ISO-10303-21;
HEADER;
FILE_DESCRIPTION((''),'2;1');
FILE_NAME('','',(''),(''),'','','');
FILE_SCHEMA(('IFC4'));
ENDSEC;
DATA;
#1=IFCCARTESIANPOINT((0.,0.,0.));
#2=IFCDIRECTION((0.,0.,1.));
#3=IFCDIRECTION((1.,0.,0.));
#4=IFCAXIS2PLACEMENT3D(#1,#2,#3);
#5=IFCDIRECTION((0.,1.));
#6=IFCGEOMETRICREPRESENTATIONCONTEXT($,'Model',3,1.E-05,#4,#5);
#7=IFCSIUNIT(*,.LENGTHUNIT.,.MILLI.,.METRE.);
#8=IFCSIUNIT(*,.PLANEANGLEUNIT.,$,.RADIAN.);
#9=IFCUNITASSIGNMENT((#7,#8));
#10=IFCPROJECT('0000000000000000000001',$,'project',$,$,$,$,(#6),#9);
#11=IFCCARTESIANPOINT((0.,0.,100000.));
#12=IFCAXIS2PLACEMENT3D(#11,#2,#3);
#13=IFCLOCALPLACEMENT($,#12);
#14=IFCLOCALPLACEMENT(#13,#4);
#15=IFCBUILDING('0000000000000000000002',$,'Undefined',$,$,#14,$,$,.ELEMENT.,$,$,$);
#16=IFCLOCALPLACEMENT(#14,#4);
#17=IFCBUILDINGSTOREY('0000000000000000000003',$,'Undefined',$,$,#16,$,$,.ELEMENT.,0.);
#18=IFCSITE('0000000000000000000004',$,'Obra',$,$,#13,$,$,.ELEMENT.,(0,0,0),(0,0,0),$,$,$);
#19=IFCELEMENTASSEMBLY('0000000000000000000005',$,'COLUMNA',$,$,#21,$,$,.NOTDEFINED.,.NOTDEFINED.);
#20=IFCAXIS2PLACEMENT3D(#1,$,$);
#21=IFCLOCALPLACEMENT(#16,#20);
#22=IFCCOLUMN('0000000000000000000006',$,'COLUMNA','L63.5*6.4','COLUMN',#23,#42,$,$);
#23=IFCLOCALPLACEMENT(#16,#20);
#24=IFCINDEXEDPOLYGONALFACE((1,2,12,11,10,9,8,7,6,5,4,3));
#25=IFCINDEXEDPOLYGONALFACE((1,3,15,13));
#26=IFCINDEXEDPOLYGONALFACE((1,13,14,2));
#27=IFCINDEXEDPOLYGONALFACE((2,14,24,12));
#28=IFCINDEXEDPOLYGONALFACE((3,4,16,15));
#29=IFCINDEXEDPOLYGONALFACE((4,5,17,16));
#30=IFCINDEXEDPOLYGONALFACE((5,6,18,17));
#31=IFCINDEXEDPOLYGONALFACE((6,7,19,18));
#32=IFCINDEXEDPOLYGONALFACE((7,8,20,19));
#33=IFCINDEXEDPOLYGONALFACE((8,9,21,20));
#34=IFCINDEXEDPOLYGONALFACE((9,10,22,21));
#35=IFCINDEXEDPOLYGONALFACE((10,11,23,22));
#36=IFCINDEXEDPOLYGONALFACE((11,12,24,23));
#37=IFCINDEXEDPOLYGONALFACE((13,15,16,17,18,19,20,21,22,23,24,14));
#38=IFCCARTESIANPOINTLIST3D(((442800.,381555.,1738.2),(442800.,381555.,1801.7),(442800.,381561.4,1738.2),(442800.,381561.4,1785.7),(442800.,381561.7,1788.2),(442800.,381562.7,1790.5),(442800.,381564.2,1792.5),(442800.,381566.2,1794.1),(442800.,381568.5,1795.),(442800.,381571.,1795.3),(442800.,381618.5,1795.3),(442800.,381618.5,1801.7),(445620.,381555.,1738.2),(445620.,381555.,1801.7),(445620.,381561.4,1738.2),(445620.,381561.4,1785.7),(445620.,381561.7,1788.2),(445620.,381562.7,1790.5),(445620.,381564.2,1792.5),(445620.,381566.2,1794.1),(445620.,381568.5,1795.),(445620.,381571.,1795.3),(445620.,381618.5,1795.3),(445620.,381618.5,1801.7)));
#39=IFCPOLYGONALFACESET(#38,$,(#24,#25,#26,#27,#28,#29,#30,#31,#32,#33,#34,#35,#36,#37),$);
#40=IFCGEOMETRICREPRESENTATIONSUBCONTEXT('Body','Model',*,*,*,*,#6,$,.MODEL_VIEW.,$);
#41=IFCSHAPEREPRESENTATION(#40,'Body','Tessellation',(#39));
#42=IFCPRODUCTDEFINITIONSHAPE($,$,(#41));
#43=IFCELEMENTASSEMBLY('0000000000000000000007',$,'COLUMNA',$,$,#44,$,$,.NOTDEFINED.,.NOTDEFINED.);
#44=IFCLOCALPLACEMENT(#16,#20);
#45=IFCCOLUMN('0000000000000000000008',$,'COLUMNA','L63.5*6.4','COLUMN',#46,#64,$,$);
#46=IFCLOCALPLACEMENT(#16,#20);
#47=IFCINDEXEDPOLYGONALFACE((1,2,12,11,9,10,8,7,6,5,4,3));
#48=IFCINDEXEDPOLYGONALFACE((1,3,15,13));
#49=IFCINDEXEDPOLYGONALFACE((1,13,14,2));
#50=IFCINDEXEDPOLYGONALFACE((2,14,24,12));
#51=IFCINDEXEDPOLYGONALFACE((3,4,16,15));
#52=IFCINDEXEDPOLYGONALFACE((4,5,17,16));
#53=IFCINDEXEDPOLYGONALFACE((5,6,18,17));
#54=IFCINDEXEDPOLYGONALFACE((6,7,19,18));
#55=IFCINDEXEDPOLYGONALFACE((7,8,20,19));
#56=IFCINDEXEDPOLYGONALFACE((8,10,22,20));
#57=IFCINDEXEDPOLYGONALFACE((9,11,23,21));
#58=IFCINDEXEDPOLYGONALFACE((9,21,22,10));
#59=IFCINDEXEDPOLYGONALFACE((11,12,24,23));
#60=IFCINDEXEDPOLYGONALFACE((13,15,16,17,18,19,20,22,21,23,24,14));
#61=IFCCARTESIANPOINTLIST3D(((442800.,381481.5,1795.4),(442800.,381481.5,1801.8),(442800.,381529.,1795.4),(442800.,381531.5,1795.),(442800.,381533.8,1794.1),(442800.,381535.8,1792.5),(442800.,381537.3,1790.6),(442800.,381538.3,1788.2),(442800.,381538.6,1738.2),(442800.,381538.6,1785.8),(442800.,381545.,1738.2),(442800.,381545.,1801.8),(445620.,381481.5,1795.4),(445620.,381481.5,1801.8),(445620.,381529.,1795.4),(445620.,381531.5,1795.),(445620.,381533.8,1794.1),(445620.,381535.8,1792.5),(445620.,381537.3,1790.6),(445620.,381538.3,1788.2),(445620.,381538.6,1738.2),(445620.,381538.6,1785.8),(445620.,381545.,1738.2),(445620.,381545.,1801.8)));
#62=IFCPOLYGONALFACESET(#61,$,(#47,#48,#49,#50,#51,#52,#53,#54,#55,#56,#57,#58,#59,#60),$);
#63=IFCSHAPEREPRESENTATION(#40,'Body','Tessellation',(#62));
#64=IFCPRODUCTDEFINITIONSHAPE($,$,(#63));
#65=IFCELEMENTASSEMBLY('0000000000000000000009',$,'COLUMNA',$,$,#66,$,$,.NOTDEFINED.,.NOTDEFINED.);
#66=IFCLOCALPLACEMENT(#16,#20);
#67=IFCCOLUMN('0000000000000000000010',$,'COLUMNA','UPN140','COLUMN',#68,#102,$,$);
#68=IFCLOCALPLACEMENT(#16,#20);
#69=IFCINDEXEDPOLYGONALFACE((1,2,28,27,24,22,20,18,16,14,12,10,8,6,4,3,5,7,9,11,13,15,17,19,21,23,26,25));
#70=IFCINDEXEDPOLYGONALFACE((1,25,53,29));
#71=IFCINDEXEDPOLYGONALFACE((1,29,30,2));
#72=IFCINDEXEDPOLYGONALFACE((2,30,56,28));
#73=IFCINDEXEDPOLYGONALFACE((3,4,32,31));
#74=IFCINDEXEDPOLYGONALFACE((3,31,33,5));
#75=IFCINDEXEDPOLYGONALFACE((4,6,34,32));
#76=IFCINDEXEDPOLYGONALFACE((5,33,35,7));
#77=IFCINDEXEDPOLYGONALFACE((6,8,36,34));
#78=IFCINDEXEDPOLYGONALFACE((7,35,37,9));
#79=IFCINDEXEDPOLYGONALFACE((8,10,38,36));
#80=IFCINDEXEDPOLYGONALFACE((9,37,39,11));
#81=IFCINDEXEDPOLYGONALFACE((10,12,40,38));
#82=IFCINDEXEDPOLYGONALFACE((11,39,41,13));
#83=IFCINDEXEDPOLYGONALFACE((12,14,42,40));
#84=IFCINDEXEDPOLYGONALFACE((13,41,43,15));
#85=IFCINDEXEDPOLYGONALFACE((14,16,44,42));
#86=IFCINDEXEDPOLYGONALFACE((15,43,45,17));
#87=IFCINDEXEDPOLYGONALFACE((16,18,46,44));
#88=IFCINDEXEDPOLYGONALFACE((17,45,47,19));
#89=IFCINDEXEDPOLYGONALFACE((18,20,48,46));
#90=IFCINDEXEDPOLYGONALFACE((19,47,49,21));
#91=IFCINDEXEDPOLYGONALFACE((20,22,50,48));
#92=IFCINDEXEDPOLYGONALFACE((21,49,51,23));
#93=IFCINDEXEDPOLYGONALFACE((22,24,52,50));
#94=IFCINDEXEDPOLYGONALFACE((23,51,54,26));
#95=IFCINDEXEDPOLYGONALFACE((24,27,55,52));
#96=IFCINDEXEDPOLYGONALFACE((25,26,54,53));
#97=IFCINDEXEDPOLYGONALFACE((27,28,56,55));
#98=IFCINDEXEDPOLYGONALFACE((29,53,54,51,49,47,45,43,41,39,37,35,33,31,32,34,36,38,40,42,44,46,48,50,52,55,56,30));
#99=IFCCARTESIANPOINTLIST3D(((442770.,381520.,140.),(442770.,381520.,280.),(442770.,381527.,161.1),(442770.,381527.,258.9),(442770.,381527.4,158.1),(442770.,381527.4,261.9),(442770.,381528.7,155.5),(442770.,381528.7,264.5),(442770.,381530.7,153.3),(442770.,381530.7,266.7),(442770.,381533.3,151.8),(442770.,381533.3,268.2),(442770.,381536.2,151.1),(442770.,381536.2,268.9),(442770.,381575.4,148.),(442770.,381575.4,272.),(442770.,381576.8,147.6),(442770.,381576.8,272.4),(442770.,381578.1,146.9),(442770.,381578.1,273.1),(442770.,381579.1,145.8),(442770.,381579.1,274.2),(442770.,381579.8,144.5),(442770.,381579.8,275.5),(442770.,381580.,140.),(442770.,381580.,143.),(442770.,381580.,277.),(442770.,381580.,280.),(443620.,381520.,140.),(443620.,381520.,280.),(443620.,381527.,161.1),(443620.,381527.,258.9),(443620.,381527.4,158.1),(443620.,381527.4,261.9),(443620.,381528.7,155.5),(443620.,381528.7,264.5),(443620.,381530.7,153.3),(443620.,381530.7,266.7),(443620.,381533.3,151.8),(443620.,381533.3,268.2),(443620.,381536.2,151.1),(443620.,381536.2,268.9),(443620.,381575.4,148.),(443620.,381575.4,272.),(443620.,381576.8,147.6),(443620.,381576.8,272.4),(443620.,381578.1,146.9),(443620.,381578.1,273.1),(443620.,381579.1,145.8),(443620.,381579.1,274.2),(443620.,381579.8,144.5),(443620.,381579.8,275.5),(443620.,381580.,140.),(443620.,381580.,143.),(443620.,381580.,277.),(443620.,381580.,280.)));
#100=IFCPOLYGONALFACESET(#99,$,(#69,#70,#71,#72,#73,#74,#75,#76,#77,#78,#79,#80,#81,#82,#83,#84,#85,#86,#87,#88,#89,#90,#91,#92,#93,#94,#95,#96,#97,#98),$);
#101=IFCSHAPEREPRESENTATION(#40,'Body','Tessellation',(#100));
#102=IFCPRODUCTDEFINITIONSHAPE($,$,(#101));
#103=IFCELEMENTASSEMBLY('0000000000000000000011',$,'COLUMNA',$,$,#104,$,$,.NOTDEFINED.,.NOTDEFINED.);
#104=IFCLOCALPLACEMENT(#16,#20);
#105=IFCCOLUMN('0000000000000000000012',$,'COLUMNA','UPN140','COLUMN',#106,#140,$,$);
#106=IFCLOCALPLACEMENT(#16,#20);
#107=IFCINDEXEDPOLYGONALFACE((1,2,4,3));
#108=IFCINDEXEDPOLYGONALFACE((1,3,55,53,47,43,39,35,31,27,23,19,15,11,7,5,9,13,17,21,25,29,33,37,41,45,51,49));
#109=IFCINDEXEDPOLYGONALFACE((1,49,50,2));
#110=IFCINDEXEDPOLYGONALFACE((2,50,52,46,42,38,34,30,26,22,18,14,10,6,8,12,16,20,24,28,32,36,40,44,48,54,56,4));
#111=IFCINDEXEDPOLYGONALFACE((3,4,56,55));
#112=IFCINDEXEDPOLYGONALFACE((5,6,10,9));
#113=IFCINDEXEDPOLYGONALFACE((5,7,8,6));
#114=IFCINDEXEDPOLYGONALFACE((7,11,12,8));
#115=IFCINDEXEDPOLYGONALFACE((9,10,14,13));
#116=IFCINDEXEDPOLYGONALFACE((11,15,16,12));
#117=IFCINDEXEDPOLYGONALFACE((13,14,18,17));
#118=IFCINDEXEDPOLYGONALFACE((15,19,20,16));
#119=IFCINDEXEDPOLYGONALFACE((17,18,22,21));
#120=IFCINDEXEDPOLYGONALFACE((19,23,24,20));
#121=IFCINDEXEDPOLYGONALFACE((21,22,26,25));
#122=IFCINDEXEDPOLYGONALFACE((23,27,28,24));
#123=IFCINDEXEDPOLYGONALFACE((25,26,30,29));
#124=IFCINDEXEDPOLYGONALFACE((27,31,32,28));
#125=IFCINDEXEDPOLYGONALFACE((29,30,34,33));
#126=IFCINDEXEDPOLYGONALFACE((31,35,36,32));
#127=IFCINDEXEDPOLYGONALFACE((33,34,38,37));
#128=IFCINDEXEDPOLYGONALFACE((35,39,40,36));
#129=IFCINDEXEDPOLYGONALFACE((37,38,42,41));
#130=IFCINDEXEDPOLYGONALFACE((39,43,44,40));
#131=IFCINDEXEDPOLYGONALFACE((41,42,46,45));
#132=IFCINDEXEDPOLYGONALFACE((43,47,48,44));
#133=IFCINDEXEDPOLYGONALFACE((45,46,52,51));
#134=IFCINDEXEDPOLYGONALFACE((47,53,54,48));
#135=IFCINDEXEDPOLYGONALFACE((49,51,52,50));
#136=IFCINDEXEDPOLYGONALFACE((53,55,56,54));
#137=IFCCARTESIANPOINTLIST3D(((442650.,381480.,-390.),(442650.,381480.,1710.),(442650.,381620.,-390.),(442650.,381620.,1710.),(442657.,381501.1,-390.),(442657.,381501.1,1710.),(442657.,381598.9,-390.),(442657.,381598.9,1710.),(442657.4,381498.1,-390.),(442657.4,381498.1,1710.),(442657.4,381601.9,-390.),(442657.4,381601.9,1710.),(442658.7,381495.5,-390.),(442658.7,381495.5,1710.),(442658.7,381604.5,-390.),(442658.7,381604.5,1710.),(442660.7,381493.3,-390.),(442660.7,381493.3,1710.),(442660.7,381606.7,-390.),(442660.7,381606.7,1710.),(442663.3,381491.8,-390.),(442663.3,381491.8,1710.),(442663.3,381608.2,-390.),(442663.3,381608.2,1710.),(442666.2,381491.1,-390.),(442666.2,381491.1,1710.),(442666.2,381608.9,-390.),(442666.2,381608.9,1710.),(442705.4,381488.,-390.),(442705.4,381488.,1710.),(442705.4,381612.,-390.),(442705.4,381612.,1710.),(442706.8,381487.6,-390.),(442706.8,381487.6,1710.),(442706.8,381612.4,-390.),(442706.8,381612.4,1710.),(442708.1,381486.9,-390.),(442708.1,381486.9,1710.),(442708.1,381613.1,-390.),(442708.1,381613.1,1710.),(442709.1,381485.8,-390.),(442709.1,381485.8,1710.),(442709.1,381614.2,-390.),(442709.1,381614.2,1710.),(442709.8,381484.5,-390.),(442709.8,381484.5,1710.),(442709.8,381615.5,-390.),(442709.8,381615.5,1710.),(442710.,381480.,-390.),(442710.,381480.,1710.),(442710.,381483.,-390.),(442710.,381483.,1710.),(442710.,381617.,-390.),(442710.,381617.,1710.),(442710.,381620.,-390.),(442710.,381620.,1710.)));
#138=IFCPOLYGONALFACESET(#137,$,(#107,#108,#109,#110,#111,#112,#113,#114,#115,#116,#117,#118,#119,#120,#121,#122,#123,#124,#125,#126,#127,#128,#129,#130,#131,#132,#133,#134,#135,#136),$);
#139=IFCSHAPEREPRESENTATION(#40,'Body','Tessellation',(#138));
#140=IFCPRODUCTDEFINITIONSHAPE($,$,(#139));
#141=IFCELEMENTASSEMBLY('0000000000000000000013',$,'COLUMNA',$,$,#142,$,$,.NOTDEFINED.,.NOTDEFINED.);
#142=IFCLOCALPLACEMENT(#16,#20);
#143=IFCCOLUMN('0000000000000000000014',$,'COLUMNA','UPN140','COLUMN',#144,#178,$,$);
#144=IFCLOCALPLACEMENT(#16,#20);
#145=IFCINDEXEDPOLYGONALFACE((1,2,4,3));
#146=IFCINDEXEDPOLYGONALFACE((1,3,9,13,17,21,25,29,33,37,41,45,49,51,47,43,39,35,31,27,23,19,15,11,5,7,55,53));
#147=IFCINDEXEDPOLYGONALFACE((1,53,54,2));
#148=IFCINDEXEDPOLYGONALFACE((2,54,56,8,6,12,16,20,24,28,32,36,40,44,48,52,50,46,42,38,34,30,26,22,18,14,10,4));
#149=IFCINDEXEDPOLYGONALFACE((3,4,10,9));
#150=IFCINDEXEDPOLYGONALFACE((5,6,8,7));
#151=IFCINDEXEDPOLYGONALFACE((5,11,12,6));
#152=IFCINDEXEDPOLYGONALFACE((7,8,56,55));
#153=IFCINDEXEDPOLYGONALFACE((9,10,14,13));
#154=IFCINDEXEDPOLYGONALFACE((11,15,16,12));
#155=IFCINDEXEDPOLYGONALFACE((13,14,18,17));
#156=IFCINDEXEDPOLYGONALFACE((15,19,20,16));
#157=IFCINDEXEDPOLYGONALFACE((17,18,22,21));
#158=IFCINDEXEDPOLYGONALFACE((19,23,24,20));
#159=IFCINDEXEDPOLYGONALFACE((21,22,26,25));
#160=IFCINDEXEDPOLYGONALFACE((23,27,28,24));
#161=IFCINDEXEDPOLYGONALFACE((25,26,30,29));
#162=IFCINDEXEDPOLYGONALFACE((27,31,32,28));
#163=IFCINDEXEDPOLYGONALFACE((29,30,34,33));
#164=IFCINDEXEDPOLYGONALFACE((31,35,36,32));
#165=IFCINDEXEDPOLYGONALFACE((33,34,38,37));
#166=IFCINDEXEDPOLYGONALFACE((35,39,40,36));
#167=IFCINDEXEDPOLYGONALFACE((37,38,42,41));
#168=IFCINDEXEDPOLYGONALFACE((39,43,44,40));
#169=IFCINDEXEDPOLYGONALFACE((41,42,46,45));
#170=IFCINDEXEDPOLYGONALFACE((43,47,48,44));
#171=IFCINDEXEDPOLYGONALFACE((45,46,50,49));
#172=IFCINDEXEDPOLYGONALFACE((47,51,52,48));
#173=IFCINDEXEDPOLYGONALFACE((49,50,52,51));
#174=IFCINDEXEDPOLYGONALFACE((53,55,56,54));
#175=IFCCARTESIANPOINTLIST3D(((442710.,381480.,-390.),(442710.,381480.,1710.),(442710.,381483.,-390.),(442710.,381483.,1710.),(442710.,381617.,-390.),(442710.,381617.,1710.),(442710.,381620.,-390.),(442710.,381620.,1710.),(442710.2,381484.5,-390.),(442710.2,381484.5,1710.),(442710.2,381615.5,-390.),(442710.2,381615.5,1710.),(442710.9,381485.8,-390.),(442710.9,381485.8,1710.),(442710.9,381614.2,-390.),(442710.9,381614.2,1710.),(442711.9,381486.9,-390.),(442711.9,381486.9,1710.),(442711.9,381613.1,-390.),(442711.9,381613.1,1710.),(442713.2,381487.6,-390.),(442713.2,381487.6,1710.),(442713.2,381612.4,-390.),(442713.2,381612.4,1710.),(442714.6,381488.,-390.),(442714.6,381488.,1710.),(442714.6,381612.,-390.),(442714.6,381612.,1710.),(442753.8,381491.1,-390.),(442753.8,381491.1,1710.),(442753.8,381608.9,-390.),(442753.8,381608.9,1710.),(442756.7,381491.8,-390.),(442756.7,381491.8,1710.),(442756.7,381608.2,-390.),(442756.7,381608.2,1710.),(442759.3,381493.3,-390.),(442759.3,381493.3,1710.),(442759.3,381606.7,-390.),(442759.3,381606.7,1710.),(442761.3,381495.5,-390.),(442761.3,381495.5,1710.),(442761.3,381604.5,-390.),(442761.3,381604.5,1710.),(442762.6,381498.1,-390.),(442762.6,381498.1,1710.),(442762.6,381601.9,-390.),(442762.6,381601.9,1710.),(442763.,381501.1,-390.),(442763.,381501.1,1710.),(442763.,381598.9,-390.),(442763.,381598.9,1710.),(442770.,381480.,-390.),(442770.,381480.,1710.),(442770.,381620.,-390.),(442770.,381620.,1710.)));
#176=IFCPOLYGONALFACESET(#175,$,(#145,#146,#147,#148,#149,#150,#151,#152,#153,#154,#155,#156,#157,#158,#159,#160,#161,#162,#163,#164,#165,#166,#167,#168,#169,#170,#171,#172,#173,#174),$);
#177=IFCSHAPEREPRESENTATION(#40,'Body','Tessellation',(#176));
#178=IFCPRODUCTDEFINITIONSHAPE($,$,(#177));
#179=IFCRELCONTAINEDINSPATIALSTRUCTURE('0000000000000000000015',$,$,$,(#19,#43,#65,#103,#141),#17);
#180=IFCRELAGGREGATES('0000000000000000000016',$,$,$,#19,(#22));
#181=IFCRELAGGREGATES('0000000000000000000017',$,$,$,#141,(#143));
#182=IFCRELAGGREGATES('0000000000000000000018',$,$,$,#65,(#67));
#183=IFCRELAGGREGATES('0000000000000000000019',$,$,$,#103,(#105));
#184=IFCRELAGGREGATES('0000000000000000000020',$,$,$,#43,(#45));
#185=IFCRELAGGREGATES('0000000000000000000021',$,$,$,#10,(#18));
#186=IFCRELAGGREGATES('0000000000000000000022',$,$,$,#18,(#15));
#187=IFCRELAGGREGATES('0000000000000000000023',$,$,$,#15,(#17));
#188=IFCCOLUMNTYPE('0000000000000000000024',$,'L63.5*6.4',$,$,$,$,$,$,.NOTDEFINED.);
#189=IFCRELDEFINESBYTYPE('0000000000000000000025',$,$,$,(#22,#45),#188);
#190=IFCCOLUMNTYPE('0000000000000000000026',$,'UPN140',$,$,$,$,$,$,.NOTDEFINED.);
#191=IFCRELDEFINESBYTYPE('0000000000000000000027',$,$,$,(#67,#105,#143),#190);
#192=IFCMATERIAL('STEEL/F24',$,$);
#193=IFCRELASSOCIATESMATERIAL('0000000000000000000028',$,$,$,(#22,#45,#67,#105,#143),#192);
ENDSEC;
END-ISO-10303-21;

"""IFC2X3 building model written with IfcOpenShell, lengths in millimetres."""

from ifc_helpers import new_model, si_unit, direction, frame, origin_with_axes, origin_2d_with_axis, place, context, subcontext, project, spatial, l_section, u_section, extrude, material, type_object, element, aggregate, save


model = new_model("IFC2X3")

# Units and contexts
model_context = context("Model", 3, precision=1e-05, world=origin_with_axes(), true_north=direction((0.0, 1.0)))
body_context = subcontext(model_context, "Body", "Model", "MODEL_VIEW")
ifc_project = project(units=[si_unit("LENGTHUNIT", "METRE", prefix="MILLI"), si_unit("PLANEANGLEUNIT", "RADIAN")], contexts=[model_context])

# Site, building, storey
site_placement = place(None, frame((0.0, 0.0, 100000.0), z_axis=(0.0, 0.0, 1.0), x_axis=(1.0, 0.0, 0.0)))
site = spatial("IfcSite", under=ifc_project, at=site_placement, Name="Obra", CompositionType="ELEMENT", RefLatitude=(0, 0, 0), RefLongitude=(0, 0, 0))
building_placement = place(site_placement, origin_with_axes())
building = spatial("IfcBuilding", under=site, at=building_placement, Name="Undefined", CompositionType="ELEMENT")
storey_placement = place(building_placement, origin_with_axes())
storey = spatial("IfcBuildingStorey", under=building, at=storey_placement, Name="Undefined", CompositionType="ELEMENT", Elevation=0.0)

# Element assemblies, columns
ifc_material_1 = material(Name="STEEL/F24")
column_type_1 = type_object("IfcColumnType", Name="L63.5*6.4", PredefinedType="NOTDEFINED")
assembly_1_placement = place(storey_placement, origin_with_axes())
assembly_1 = element("IfcElementAssembly", 1, at=assembly_1_placement, inside=storey, Name="COLUMNA", AssemblyPlace="NOTDEFINED", PredefinedType="NOTDEFINED")
column_1_placement = place(assembly_1_placement, frame((442800.0, 381586.7, 1770.0), z_axis=(1.0, 0.0, 0.0), x_axis=(0.0, 0.0, -1.0)))
column_1 = element("IfcColumn", 2, at=column_1_placement, type_object=column_type_1, material=ifc_material_1, Name="COLUMNA", Description="L63.5*6.4", ObjectType="COLUMN", context=body_context, shape_type="SweptSolid", body=[
    extrude(l_section(Depth=63.5, Width=63.5, Thickness=6.4, FilletRadius=9.6, at=origin_2d_with_axis()), frame((0.0, 0.0, 2820.0), z_axis=(0.0, 0.0, -1.0), x_axis=(0.0, 1.0, 0.0)), (0.0, 0.0, 1.0), 2820.0),
])
aggregate(assembly_1, [column_1])
assembly_2_placement = place(storey_placement, origin_with_axes())
assembly_2 = element("IfcElementAssembly", 3, at=assembly_2_placement, inside=storey, Name="COLUMNA", AssemblyPlace="NOTDEFINED", PredefinedType="NOTDEFINED")
column_2_placement = place(assembly_2_placement, frame((442800.0, 381513.2, 1770.0), z_axis=(1.0, 0.0, 0.0), x_axis=(0.0, -1.0, 0.0)))
column_2 = element("IfcColumn", 4, at=column_2_placement, type_object=column_type_1, material=ifc_material_1, Name="COLUMNA", Description="L63.5*6.4", ObjectType="COLUMN", context=body_context, shape_type="SweptSolid", body=[
    extrude(l_section(Depth=63.5, Width=63.5, Thickness=6.4, FilletRadius=9.6, at=origin_2d_with_axis()), frame((0.0, 0.0, 2820.0), z_axis=(0.0, 0.0, -1.0), x_axis=(0.0, 1.0, 0.0)), (0.0, 0.0, 1.0), 2820.0),
])
assembly_3_placement = place(storey_placement, origin_with_axes())
assembly_3 = element("IfcElementAssembly", 5, at=assembly_3_placement, inside=storey, Name="COLUMNA", AssemblyPlace="NOTDEFINED", PredefinedType="NOTDEFINED")
column_type_2 = type_object("IfcColumnType", Name="UPN140", PredefinedType="NOTDEFINED")
column_3_placement = place(assembly_3_placement, frame((442770.0, 381550.0, 210.0), z_axis=(1.0, 0.0, 0.0), x_axis=(0.0, 0.0, -1.0)))
column_3 = element("IfcColumn", 6, at=column_3_placement, type_object=column_type_2, material=ifc_material_1, Name="COLUMNA", Description="UPN140", ObjectType="COLUMN", context=body_context, shape_type="SweptSolid", body=[
    extrude(u_section(Depth=140.0, FlangeWidth=60.0, WebThickness=7.0, FlangeThickness=10.0, FilletRadius=10.0, EdgeRadius=5.0, FlangeSlope=0.07983, at=origin_2d_with_axis()), frame((0.0, 0.0, 850.0), z_axis=(0.0, 0.0, -1.0), x_axis=(0.0, 1.0, 0.0)), (0.0, 0.0, 1.0), 850.0),
])
assembly_4_placement = place(storey_placement, origin_with_axes())
assembly_4 = element("IfcElementAssembly", 7, at=assembly_4_placement, inside=storey, Name="COLUMNA", AssemblyPlace="NOTDEFINED", PredefinedType="NOTDEFINED")
column_4_placement = place(assembly_4_placement, frame((442680.0, 381550.0, 1710.0), z_axis=(0.0, 0.0, -1.0), x_axis=(0.0, 1.0, 0.0)))
column_4 = element("IfcColumn", 8, at=column_4_placement, type_object=column_type_2, material=ifc_material_1, Name="COLUMNA", Description="UPN140", ObjectType="COLUMN", context=body_context, shape_type="SweptSolid", body=[
    extrude(u_section(Depth=140.0, FlangeWidth=60.0, WebThickness=7.0, FlangeThickness=10.0, FilletRadius=10.0, EdgeRadius=5.0, FlangeSlope=0.07983, at=origin_2d_with_axis()), frame((0.0, 0.0, 2100.0), z_axis=(0.0, 0.0, -1.0), x_axis=(0.0, 1.0, 0.0)), (0.0, 0.0, 1.0), 2100.0),
])
assembly_5_placement = place(storey_placement, origin_with_axes())
assembly_5 = element("IfcElementAssembly", 9, at=assembly_5_placement, inside=storey, Name="COLUMNA", AssemblyPlace="NOTDEFINED", PredefinedType="NOTDEFINED")
column_5_placement = place(assembly_5_placement, frame((442740.0, 381550.0, 1710.0), z_axis=(0.0, 0.0, -1.0), x_axis=(0.0, -1.0, 0.0)))
column_5 = element("IfcColumn", 10, at=column_5_placement, type_object=column_type_2, material=ifc_material_1, Name="COLUMNA", Description="UPN140", ObjectType="COLUMN", context=body_context, shape_type="SweptSolid", body=[
    extrude(u_section(Depth=140.0, FlangeWidth=60.0, WebThickness=7.0, FlangeThickness=10.0, FilletRadius=10.0, EdgeRadius=5.0, FlangeSlope=0.07983, at=origin_2d_with_axis()), frame((0.0, 0.0, 2100.0), z_axis=(0.0, 0.0, -1.0), x_axis=(0.0, 1.0, 0.0)), (0.0, 0.0, 1.0), 2100.0),
])
aggregate(assembly_5, [column_5])

aggregate(assembly_3, [column_3])
aggregate(assembly_4, [column_4])

aggregate(assembly_2, [column_2])

save(model, "model.ifc")
